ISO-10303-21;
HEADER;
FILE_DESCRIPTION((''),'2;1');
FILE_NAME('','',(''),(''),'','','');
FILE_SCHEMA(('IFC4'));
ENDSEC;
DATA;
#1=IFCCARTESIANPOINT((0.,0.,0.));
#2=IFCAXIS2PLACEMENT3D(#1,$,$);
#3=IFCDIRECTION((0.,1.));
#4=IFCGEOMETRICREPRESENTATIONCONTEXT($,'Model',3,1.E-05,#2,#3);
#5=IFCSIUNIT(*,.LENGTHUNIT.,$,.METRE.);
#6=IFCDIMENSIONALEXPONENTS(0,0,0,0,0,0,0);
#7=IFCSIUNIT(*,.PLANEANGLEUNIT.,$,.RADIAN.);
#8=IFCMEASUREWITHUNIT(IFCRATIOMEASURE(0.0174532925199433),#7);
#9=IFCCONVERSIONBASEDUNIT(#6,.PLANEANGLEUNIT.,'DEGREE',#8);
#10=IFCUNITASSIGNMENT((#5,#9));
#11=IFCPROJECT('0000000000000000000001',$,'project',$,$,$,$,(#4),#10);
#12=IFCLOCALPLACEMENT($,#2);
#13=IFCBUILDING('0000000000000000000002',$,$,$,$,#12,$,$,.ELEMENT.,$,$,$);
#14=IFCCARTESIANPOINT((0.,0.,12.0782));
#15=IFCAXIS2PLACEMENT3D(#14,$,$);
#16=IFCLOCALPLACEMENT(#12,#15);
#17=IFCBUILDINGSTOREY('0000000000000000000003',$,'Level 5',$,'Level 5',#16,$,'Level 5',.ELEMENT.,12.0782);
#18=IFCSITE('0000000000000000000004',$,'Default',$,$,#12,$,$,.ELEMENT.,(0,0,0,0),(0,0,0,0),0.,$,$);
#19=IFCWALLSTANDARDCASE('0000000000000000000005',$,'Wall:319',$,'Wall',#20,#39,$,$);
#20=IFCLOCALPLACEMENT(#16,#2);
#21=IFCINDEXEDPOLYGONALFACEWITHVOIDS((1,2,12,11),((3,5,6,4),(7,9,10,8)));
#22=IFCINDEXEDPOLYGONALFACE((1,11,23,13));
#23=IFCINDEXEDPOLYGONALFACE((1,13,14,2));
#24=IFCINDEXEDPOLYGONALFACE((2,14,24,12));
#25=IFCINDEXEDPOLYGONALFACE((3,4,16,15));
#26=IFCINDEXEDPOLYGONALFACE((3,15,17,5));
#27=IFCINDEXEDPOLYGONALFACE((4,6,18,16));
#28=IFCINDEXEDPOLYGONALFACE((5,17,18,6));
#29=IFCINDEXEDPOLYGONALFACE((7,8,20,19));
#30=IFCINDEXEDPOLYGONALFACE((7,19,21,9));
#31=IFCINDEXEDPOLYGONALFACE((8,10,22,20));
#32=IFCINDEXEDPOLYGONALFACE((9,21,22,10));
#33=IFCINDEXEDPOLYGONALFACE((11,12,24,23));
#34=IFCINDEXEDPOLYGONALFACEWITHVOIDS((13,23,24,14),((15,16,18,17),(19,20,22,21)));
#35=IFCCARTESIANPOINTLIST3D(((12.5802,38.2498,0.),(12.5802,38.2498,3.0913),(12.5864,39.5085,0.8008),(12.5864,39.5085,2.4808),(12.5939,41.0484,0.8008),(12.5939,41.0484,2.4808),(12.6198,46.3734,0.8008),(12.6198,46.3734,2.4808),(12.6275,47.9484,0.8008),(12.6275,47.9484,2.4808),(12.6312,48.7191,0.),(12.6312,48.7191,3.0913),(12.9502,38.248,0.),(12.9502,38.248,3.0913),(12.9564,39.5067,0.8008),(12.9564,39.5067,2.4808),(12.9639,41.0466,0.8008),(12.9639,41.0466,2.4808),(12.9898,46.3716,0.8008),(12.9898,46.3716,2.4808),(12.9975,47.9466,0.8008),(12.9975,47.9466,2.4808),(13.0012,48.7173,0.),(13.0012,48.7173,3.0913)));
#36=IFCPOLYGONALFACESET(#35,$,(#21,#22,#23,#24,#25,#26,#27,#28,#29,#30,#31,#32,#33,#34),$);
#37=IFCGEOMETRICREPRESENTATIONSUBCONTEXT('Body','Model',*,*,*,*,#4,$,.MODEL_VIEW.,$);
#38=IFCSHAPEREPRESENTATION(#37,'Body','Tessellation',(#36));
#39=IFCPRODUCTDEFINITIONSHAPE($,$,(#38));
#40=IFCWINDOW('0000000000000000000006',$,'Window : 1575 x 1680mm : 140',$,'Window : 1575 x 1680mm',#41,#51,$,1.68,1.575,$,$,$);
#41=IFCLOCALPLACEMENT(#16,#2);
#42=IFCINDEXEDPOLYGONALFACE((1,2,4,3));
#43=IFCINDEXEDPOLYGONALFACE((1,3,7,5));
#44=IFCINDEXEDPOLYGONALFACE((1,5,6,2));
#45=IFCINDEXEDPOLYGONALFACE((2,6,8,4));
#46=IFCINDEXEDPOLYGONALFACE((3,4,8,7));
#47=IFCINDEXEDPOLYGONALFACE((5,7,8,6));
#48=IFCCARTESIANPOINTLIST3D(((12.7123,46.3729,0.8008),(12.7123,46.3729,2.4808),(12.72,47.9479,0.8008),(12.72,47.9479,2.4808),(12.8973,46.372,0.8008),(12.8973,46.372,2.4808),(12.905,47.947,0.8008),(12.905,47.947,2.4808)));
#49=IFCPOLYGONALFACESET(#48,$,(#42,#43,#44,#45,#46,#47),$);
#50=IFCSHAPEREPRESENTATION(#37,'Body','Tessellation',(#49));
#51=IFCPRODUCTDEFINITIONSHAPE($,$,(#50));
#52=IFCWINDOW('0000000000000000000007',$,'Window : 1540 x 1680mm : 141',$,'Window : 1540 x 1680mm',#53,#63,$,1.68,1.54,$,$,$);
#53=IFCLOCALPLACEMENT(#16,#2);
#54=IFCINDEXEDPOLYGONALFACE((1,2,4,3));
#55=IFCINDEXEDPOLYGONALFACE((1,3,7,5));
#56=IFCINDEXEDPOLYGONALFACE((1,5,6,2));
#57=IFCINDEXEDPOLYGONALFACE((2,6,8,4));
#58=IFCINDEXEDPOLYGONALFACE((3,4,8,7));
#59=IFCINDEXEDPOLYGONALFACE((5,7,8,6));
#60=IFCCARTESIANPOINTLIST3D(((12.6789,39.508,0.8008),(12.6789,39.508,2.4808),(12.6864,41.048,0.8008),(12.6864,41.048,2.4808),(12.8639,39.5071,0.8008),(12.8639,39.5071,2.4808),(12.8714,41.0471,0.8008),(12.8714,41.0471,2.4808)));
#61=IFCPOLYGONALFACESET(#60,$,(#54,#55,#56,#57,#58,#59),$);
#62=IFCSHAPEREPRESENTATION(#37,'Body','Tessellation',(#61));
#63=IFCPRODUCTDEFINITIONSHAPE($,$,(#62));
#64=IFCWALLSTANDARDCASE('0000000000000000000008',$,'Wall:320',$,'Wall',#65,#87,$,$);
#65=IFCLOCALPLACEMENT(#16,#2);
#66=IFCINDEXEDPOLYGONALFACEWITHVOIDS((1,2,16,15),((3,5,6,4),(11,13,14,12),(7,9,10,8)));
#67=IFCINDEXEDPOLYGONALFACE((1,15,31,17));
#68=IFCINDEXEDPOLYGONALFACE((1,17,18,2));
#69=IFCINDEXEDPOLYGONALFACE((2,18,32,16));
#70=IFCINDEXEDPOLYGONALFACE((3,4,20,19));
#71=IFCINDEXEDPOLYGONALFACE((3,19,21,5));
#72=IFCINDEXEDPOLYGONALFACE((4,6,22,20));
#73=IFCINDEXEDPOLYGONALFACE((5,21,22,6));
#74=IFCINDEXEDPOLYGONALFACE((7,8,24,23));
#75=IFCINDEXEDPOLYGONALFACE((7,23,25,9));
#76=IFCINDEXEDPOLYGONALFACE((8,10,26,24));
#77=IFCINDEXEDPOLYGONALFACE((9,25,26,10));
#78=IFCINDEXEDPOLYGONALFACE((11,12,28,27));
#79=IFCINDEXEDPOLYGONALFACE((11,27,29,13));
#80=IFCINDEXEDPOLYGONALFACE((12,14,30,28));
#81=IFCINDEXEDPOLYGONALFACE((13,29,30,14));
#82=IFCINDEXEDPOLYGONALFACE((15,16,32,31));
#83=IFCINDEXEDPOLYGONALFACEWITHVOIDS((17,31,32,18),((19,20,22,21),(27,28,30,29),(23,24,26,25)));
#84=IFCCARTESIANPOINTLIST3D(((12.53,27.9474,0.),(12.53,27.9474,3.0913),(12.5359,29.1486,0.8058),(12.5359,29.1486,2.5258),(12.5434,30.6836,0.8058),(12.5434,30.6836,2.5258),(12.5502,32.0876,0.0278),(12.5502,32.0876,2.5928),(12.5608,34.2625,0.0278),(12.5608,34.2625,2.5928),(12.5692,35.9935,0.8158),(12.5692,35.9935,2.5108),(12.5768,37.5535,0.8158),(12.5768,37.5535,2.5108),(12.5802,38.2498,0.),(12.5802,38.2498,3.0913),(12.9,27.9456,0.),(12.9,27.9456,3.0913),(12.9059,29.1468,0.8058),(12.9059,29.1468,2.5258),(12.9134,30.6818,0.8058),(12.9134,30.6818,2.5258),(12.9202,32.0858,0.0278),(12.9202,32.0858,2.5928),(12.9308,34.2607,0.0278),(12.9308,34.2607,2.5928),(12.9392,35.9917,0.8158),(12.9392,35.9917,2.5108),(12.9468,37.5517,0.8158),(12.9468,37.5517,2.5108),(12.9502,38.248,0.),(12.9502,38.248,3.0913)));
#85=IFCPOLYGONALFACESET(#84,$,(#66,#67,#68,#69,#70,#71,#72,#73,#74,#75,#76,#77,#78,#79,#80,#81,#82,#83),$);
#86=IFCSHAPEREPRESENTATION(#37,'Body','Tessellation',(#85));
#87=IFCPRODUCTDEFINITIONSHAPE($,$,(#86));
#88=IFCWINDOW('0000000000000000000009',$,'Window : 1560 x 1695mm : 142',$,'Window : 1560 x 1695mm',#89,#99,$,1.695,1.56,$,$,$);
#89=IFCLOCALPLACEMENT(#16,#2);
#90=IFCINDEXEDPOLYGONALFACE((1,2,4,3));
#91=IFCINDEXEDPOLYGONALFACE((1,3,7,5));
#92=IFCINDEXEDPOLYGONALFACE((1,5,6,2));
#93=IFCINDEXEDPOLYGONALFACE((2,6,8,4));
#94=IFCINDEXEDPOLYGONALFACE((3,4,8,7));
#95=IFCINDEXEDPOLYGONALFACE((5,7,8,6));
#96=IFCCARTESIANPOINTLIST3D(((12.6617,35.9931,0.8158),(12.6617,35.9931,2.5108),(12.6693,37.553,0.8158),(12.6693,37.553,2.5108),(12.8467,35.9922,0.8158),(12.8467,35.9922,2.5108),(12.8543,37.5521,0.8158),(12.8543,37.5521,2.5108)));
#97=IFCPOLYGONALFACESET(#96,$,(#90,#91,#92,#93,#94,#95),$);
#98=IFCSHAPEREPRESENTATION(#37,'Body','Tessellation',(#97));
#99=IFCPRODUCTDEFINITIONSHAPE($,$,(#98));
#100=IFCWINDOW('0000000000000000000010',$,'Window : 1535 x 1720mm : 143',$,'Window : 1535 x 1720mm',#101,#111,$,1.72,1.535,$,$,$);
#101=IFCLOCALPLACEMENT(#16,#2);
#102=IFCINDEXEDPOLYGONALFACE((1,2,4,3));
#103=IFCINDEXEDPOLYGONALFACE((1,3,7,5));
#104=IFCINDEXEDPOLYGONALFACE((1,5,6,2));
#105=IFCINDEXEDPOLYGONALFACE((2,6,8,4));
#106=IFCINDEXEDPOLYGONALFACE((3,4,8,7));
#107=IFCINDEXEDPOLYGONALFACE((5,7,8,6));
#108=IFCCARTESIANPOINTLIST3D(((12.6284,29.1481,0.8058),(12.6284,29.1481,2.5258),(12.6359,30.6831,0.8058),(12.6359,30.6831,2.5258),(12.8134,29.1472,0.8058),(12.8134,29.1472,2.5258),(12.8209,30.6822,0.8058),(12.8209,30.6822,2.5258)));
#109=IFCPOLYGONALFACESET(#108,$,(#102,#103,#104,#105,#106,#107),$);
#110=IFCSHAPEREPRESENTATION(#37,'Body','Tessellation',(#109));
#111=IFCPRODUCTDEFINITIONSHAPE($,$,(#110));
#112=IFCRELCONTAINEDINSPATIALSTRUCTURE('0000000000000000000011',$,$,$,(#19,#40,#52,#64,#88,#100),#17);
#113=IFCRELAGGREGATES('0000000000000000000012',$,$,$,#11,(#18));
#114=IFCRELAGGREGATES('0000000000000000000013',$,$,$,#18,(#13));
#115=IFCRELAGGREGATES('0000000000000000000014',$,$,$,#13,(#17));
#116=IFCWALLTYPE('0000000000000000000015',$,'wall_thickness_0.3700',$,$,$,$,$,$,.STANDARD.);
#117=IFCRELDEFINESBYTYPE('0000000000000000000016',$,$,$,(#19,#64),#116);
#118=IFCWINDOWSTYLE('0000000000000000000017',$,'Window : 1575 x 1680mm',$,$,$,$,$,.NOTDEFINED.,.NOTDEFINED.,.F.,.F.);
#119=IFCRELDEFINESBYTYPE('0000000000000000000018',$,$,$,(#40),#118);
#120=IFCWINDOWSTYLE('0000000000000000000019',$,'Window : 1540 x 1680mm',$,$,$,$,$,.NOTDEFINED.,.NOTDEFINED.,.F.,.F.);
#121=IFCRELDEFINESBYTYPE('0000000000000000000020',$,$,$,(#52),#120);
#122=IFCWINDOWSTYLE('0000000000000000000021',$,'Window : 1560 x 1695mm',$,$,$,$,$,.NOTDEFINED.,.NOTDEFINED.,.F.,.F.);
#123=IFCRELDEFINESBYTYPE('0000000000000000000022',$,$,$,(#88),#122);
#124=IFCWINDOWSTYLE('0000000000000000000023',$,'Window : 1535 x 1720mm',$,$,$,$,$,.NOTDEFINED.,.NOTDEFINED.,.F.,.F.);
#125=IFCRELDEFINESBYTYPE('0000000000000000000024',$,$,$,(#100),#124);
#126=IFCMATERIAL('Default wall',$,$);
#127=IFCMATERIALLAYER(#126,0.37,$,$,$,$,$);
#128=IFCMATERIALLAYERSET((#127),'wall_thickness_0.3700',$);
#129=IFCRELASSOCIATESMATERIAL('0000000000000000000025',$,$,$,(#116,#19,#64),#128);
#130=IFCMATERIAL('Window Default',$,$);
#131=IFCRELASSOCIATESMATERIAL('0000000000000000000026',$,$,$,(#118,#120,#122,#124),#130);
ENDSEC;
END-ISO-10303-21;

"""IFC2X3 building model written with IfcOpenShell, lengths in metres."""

from ifc_helpers import new_model, entity, si_unit, converted_unit, direction, frame, frame_2d, origin, origin_2d_with_axis, place, context, subcontext, project, spatial, polyline, rectangle, outline, extrude, clip, halfspace, source, transform, mapped, material, layer, layer_set, layer_usage, type_object, type_shapes, element, fill, save


model = new_model("IFC2X3")

# Units and contexts
model_context = context("Model", 3, precision=1e-05, world=origin(), true_north=direction((0.0, 1.0)))
body_context = subcontext(model_context, "Body", "Model", "MODEL_VIEW")
ifc_project = project(units=[si_unit("LENGTHUNIT", "METRE"), converted_unit("PLANEANGLEUNIT", "DEGREE", entity("IfcRatioMeasure", 0.0174532925199433), si_unit("PLANEANGLEUNIT", "RADIAN"), dimensions=[0, 0, 0, 0, 0, 0, 0])], contexts=[model_context])

# Site, building, storey
placement = place(None, origin())
site = spatial("IfcSite", under=ifc_project, at=placement, Name="Default", CompositionType="ELEMENT", RefLatitude=(0, 0, 0, 0), RefLongitude=(0, 0, 0, 0), RefElevation=0.0)
building = spatial("IfcBuilding", under=site, at=placement, CompositionType="ELEMENT")
storey_placement = place(placement, frame((0.0, 0.0, 12.0782)))
storey = spatial("IfcBuildingStorey", under=building, at=storey_placement, Name="Level 5", ObjectType="Level 5", LongName="Level 5", CompositionType="ELEMENT", Elevation=12.0782)

# Shared definitions
ifc_material_1 = material(Name="Default wall")

# Walls, openings, windows
ifc_layer_1 = layer(ifc_material_1, 0.37)
ifc_layer_set_1 = layer_set([ifc_layer_1], Name="wall_thickness_0.3700")
ifc_layer_usage_1 = layer_usage(ifc_layer_set_1, "AXIS2", "POSITIVE", -0.185)
wall_type_1 = type_object("IfcWallType", Name="wall_thickness_0.3700", PredefinedType="STANDARD", material=ifc_layer_set_1)
wall_1_placement = place(storey_placement, frame((12.8162, 48.7182, 0.0), z_axis=(0.0, 0.0, 1.0), x_axis=(-0.004871, -0.999988, 0.0)))
wall_1 = element("IfcWallStandardCase", 1, at=wall_1_placement, inside=storey, type_object=wall_type_1, material=ifc_layer_usage_1, Name="Wall:319", ObjectType="Wall", context=body_context, shape_type="Clipping", body=[
    clip(extrude(outline(polyline([(10.4695, -0.185), (10.4695, 0.185), (0.0, 0.185), (0.0, -0.185), (10.4695, -0.185)])), origin(), (0.0, 0.0, 1.0), 3.0913), halfspace(frame((-28.518, -0.1386, 6.3586), z_axis=(0.000002, 0.3905, 0.920603), x_axis=(0.673581, -0.680431, 0.288623)), False)),
])
opening_1_placement = place(wall_1_placement, frame((0.7708, -0.185, 0.8008)))
opening_1 = element("IfcOpeningElement", 2, at=opening_1_placement, cuts=wall_1, ObjectType="Opening", context=body_context, shape_type="SweptSolid", body=[
    extrude(rectangle(XDim=1.575, YDim=1.68, at=frame_2d((0.84, 0.7875), x_axis=(0.0, 1.0))), frame((0.0, 0.0, 0.0), z_axis=(0.0, 1.0, 0.0), x_axis=(0.0, 0.0, 1.0)), (0.0, 0.0, 1.0), 0.37),
])
opening_2_placement = place(wall_1_placement, frame((7.6708, -0.185, 0.8008)))
opening_2 = element("IfcOpeningElement", 3, at=opening_2_placement, cuts=wall_1, ObjectType="Opening", context=body_context, shape_type="SweptSolid", body=[
    extrude(rectangle(XDim=1.54, YDim=1.68, at=frame_2d((0.84, 0.77), x_axis=(0.0, 1.0))), frame((0.0, 0.0, 0.0), z_axis=(0.0, 1.0, 0.0), x_axis=(0.0, 0.0, 1.0)), (0.0, 0.0, 1.0), 0.37),
])
ifc_material_2 = material(Name="Window Default")
window_style_1 = type_object("IfcWindowStyle", Name="Window : 1575 x 1680mm", ConstructionType="NOTDEFINED", OperationType="NOTDEFINED", ParameterTakesPrecedence=False, Sizeable=False, material=ifc_material_2)
shared_shape_1 = source(origin(), body_context, "Body", "SweptSolid", [
    extrude(rectangle(XDim=0.185, YDim=1.575, at=origin_2d_with_axis()), frame((0.7875, 0.185, 0.0), z_axis=(0.0, 0.0, 1.0), x_axis=(0.0, 1.0, 0.0)), (0.0, 0.0, 1.0), 1.68),
])
type_shapes(window_style_1, [shared_shape_1])
window_1_placement = place(opening_1_placement, origin())
window_1 = element("IfcWindow", 4, at=window_1_placement, inside=storey, type_object=window_style_1, Name="Window : 1575 x 1680mm : 140", ObjectType="Window : 1575 x 1680mm", OverallHeight=1.68, OverallWidth=1.575, context=body_context, shape_type="MappedRepresentation", body=[
    mapped(shared_shape_1, transform((0.0, 0.0, 0.0), scale=1.0)),
])
fill(opening_1, window_1)
window_style_2 = type_object("IfcWindowStyle", Name="Window : 1540 x 1680mm", ConstructionType="NOTDEFINED", OperationType="NOTDEFINED", ParameterTakesPrecedence=False, Sizeable=False, material=ifc_material_2)
shared_shape_2 = source(origin(), body_context, "Body", "SweptSolid", [
    extrude(rectangle(XDim=0.185, YDim=1.54, at=origin_2d_with_axis()), frame((0.77, 0.185, 0.0), z_axis=(0.0, 0.0, 1.0), x_axis=(0.0, 1.0, 0.0)), (0.0, 0.0, 1.0), 1.68),
])
type_shapes(window_style_2, [shared_shape_2])
window_2_placement = place(opening_2_placement, origin())
window_2 = element("IfcWindow", 5, at=window_2_placement, inside=storey, type_object=window_style_2, Name="Window : 1540 x 1680mm : 141", ObjectType="Window : 1540 x 1680mm", OverallHeight=1.68, OverallWidth=1.54, context=body_context, shape_type="MappedRepresentation", body=[
    mapped(shared_shape_2, transform((0.0, 0.0, 0.0), scale=1.0)),
])
fill(opening_2, window_2)
wall_2_placement = place(storey_placement, frame((12.7652, 38.2489, 0.0), z_axis=(0.0, 0.0, 1.0), x_axis=(-0.004871, -0.999988, 0.0)))
wall_2 = element("IfcWallStandardCase", 6, at=wall_2_placement, inside=storey, type_object=wall_type_1, material=ifc_layer_usage_1, Name="Wall:320", ObjectType="Wall", context=body_context, shape_type="Clipping", body=[
    clip(extrude(outline(polyline([(10.3025, -0.185), (10.3025, 0.185), (0.0, 0.185), (0.0, -0.185), (10.3025, -0.185)])), origin(), (0.0, 0.0, 1.0), 3.0913), halfspace(frame((-38.9875, -0.1386, 6.3586), z_axis=(0.000002, 0.3905, 0.920603), x_axis=(0.673581, -0.680431, 0.288623)), False)),
])
opening_3_placement = place(wall_2_placement, frame((3.9873, -0.185, 0.0278)))
element("IfcOpeningElement", 7, at=opening_3_placement, cuts=wall_2, ObjectType="Opening", context=body_context, shape_type="SweptSolid", body=[
    extrude(rectangle(XDim=2.175, YDim=2.565, at=frame_2d((1.2825, 1.0875), x_axis=(0.0, 1.0))), frame((0.0, 0.0, 0.0), z_axis=(0.0, 1.0, 0.0), x_axis=(0.0, 0.0, 1.0)), (0.0, 0.0, 1.0), 0.37),
])
opening_4_placement = place(wall_2_placement, frame((0.6963, -0.185, 0.8158)))
opening_4 = element("IfcOpeningElement", 8, at=opening_4_placement, cuts=wall_2, ObjectType="Opening", context=body_context, shape_type="SweptSolid", body=[
    extrude(rectangle(XDim=1.56, YDim=1.695, at=frame_2d((0.8475, 0.78), x_axis=(0.0, 1.0))), frame((0.0, 0.0, 0.0), z_axis=(0.0, 1.0, 0.0), x_axis=(0.0, 0.0, 1.0)), (0.0, 0.0, 1.0), 0.37),
])
opening_5_placement = place(wall_2_placement, frame((7.5663, -0.185, 0.8058)))
opening_5 = element("IfcOpeningElement", 9, at=opening_5_placement, cuts=wall_2, ObjectType="Opening", context=body_context, shape_type="SweptSolid", body=[
    extrude(rectangle(XDim=1.535, YDim=1.72, at=frame_2d((0.86, 0.7675), x_axis=(0.0, 1.0))), frame((0.0, 0.0, 0.0), z_axis=(0.0, 1.0, 0.0), x_axis=(0.0, 0.0, 1.0)), (0.0, 0.0, 1.0), 0.37),
])
window_style_3 = type_object("IfcWindowStyle", Name="Window : 1560 x 1695mm", ConstructionType="NOTDEFINED", OperationType="NOTDEFINED", ParameterTakesPrecedence=False, Sizeable=False, material=ifc_material_2)
shared_shape_3 = source(origin(), body_context, "Body", "SweptSolid", [
    extrude(rectangle(XDim=0.185, YDim=1.56, at=origin_2d_with_axis()), frame((0.78, 0.185, 0.0), z_axis=(0.0, 0.0, 1.0), x_axis=(0.0, 1.0, 0.0)), (0.0, 0.0, 1.0), 1.695),
])
type_shapes(window_style_3, [shared_shape_3])
window_3_placement = place(opening_4_placement, origin())
window_3 = element("IfcWindow", 10, at=window_3_placement, inside=storey, type_object=window_style_3, Name="Window : 1560 x 1695mm : 142", ObjectType="Window : 1560 x 1695mm", OverallHeight=1.695, OverallWidth=1.56, context=body_context, shape_type="MappedRepresentation", body=[
    mapped(shared_shape_3, transform((0.0, 0.0, 0.0), scale=1.0)),
])
fill(opening_4, window_3)
window_style_4 = type_object("IfcWindowStyle", Name="Window : 1535 x 1720mm", ConstructionType="NOTDEFINED", OperationType="NOTDEFINED", ParameterTakesPrecedence=False, Sizeable=False, material=ifc_material_2)
shared_shape_4 = source(origin(), body_context, "Body", "SweptSolid", [
    extrude(rectangle(XDim=0.185, YDim=1.535, at=origin_2d_with_axis()), frame((0.7675, 0.185, 0.0), z_axis=(0.0, 0.0, 1.0), x_axis=(0.0, 1.0, 0.0)), (0.0, 0.0, 1.0), 1.72),
])
type_shapes(window_style_4, [shared_shape_4])
window_4_placement = place(opening_5_placement, origin())
window_4 = element("IfcWindow", 11, at=window_4_placement, inside=storey, type_object=window_style_4, Name="Window : 1535 x 1720mm : 143", ObjectType="Window : 1535 x 1720mm", OverallHeight=1.72, OverallWidth=1.535, context=body_context, shape_type="MappedRepresentation", body=[
    mapped(shared_shape_4, transform((0.0, 0.0, 0.0), scale=1.0)),
])
fill(opening_5, window_4)

save(model, "model.ifc")
